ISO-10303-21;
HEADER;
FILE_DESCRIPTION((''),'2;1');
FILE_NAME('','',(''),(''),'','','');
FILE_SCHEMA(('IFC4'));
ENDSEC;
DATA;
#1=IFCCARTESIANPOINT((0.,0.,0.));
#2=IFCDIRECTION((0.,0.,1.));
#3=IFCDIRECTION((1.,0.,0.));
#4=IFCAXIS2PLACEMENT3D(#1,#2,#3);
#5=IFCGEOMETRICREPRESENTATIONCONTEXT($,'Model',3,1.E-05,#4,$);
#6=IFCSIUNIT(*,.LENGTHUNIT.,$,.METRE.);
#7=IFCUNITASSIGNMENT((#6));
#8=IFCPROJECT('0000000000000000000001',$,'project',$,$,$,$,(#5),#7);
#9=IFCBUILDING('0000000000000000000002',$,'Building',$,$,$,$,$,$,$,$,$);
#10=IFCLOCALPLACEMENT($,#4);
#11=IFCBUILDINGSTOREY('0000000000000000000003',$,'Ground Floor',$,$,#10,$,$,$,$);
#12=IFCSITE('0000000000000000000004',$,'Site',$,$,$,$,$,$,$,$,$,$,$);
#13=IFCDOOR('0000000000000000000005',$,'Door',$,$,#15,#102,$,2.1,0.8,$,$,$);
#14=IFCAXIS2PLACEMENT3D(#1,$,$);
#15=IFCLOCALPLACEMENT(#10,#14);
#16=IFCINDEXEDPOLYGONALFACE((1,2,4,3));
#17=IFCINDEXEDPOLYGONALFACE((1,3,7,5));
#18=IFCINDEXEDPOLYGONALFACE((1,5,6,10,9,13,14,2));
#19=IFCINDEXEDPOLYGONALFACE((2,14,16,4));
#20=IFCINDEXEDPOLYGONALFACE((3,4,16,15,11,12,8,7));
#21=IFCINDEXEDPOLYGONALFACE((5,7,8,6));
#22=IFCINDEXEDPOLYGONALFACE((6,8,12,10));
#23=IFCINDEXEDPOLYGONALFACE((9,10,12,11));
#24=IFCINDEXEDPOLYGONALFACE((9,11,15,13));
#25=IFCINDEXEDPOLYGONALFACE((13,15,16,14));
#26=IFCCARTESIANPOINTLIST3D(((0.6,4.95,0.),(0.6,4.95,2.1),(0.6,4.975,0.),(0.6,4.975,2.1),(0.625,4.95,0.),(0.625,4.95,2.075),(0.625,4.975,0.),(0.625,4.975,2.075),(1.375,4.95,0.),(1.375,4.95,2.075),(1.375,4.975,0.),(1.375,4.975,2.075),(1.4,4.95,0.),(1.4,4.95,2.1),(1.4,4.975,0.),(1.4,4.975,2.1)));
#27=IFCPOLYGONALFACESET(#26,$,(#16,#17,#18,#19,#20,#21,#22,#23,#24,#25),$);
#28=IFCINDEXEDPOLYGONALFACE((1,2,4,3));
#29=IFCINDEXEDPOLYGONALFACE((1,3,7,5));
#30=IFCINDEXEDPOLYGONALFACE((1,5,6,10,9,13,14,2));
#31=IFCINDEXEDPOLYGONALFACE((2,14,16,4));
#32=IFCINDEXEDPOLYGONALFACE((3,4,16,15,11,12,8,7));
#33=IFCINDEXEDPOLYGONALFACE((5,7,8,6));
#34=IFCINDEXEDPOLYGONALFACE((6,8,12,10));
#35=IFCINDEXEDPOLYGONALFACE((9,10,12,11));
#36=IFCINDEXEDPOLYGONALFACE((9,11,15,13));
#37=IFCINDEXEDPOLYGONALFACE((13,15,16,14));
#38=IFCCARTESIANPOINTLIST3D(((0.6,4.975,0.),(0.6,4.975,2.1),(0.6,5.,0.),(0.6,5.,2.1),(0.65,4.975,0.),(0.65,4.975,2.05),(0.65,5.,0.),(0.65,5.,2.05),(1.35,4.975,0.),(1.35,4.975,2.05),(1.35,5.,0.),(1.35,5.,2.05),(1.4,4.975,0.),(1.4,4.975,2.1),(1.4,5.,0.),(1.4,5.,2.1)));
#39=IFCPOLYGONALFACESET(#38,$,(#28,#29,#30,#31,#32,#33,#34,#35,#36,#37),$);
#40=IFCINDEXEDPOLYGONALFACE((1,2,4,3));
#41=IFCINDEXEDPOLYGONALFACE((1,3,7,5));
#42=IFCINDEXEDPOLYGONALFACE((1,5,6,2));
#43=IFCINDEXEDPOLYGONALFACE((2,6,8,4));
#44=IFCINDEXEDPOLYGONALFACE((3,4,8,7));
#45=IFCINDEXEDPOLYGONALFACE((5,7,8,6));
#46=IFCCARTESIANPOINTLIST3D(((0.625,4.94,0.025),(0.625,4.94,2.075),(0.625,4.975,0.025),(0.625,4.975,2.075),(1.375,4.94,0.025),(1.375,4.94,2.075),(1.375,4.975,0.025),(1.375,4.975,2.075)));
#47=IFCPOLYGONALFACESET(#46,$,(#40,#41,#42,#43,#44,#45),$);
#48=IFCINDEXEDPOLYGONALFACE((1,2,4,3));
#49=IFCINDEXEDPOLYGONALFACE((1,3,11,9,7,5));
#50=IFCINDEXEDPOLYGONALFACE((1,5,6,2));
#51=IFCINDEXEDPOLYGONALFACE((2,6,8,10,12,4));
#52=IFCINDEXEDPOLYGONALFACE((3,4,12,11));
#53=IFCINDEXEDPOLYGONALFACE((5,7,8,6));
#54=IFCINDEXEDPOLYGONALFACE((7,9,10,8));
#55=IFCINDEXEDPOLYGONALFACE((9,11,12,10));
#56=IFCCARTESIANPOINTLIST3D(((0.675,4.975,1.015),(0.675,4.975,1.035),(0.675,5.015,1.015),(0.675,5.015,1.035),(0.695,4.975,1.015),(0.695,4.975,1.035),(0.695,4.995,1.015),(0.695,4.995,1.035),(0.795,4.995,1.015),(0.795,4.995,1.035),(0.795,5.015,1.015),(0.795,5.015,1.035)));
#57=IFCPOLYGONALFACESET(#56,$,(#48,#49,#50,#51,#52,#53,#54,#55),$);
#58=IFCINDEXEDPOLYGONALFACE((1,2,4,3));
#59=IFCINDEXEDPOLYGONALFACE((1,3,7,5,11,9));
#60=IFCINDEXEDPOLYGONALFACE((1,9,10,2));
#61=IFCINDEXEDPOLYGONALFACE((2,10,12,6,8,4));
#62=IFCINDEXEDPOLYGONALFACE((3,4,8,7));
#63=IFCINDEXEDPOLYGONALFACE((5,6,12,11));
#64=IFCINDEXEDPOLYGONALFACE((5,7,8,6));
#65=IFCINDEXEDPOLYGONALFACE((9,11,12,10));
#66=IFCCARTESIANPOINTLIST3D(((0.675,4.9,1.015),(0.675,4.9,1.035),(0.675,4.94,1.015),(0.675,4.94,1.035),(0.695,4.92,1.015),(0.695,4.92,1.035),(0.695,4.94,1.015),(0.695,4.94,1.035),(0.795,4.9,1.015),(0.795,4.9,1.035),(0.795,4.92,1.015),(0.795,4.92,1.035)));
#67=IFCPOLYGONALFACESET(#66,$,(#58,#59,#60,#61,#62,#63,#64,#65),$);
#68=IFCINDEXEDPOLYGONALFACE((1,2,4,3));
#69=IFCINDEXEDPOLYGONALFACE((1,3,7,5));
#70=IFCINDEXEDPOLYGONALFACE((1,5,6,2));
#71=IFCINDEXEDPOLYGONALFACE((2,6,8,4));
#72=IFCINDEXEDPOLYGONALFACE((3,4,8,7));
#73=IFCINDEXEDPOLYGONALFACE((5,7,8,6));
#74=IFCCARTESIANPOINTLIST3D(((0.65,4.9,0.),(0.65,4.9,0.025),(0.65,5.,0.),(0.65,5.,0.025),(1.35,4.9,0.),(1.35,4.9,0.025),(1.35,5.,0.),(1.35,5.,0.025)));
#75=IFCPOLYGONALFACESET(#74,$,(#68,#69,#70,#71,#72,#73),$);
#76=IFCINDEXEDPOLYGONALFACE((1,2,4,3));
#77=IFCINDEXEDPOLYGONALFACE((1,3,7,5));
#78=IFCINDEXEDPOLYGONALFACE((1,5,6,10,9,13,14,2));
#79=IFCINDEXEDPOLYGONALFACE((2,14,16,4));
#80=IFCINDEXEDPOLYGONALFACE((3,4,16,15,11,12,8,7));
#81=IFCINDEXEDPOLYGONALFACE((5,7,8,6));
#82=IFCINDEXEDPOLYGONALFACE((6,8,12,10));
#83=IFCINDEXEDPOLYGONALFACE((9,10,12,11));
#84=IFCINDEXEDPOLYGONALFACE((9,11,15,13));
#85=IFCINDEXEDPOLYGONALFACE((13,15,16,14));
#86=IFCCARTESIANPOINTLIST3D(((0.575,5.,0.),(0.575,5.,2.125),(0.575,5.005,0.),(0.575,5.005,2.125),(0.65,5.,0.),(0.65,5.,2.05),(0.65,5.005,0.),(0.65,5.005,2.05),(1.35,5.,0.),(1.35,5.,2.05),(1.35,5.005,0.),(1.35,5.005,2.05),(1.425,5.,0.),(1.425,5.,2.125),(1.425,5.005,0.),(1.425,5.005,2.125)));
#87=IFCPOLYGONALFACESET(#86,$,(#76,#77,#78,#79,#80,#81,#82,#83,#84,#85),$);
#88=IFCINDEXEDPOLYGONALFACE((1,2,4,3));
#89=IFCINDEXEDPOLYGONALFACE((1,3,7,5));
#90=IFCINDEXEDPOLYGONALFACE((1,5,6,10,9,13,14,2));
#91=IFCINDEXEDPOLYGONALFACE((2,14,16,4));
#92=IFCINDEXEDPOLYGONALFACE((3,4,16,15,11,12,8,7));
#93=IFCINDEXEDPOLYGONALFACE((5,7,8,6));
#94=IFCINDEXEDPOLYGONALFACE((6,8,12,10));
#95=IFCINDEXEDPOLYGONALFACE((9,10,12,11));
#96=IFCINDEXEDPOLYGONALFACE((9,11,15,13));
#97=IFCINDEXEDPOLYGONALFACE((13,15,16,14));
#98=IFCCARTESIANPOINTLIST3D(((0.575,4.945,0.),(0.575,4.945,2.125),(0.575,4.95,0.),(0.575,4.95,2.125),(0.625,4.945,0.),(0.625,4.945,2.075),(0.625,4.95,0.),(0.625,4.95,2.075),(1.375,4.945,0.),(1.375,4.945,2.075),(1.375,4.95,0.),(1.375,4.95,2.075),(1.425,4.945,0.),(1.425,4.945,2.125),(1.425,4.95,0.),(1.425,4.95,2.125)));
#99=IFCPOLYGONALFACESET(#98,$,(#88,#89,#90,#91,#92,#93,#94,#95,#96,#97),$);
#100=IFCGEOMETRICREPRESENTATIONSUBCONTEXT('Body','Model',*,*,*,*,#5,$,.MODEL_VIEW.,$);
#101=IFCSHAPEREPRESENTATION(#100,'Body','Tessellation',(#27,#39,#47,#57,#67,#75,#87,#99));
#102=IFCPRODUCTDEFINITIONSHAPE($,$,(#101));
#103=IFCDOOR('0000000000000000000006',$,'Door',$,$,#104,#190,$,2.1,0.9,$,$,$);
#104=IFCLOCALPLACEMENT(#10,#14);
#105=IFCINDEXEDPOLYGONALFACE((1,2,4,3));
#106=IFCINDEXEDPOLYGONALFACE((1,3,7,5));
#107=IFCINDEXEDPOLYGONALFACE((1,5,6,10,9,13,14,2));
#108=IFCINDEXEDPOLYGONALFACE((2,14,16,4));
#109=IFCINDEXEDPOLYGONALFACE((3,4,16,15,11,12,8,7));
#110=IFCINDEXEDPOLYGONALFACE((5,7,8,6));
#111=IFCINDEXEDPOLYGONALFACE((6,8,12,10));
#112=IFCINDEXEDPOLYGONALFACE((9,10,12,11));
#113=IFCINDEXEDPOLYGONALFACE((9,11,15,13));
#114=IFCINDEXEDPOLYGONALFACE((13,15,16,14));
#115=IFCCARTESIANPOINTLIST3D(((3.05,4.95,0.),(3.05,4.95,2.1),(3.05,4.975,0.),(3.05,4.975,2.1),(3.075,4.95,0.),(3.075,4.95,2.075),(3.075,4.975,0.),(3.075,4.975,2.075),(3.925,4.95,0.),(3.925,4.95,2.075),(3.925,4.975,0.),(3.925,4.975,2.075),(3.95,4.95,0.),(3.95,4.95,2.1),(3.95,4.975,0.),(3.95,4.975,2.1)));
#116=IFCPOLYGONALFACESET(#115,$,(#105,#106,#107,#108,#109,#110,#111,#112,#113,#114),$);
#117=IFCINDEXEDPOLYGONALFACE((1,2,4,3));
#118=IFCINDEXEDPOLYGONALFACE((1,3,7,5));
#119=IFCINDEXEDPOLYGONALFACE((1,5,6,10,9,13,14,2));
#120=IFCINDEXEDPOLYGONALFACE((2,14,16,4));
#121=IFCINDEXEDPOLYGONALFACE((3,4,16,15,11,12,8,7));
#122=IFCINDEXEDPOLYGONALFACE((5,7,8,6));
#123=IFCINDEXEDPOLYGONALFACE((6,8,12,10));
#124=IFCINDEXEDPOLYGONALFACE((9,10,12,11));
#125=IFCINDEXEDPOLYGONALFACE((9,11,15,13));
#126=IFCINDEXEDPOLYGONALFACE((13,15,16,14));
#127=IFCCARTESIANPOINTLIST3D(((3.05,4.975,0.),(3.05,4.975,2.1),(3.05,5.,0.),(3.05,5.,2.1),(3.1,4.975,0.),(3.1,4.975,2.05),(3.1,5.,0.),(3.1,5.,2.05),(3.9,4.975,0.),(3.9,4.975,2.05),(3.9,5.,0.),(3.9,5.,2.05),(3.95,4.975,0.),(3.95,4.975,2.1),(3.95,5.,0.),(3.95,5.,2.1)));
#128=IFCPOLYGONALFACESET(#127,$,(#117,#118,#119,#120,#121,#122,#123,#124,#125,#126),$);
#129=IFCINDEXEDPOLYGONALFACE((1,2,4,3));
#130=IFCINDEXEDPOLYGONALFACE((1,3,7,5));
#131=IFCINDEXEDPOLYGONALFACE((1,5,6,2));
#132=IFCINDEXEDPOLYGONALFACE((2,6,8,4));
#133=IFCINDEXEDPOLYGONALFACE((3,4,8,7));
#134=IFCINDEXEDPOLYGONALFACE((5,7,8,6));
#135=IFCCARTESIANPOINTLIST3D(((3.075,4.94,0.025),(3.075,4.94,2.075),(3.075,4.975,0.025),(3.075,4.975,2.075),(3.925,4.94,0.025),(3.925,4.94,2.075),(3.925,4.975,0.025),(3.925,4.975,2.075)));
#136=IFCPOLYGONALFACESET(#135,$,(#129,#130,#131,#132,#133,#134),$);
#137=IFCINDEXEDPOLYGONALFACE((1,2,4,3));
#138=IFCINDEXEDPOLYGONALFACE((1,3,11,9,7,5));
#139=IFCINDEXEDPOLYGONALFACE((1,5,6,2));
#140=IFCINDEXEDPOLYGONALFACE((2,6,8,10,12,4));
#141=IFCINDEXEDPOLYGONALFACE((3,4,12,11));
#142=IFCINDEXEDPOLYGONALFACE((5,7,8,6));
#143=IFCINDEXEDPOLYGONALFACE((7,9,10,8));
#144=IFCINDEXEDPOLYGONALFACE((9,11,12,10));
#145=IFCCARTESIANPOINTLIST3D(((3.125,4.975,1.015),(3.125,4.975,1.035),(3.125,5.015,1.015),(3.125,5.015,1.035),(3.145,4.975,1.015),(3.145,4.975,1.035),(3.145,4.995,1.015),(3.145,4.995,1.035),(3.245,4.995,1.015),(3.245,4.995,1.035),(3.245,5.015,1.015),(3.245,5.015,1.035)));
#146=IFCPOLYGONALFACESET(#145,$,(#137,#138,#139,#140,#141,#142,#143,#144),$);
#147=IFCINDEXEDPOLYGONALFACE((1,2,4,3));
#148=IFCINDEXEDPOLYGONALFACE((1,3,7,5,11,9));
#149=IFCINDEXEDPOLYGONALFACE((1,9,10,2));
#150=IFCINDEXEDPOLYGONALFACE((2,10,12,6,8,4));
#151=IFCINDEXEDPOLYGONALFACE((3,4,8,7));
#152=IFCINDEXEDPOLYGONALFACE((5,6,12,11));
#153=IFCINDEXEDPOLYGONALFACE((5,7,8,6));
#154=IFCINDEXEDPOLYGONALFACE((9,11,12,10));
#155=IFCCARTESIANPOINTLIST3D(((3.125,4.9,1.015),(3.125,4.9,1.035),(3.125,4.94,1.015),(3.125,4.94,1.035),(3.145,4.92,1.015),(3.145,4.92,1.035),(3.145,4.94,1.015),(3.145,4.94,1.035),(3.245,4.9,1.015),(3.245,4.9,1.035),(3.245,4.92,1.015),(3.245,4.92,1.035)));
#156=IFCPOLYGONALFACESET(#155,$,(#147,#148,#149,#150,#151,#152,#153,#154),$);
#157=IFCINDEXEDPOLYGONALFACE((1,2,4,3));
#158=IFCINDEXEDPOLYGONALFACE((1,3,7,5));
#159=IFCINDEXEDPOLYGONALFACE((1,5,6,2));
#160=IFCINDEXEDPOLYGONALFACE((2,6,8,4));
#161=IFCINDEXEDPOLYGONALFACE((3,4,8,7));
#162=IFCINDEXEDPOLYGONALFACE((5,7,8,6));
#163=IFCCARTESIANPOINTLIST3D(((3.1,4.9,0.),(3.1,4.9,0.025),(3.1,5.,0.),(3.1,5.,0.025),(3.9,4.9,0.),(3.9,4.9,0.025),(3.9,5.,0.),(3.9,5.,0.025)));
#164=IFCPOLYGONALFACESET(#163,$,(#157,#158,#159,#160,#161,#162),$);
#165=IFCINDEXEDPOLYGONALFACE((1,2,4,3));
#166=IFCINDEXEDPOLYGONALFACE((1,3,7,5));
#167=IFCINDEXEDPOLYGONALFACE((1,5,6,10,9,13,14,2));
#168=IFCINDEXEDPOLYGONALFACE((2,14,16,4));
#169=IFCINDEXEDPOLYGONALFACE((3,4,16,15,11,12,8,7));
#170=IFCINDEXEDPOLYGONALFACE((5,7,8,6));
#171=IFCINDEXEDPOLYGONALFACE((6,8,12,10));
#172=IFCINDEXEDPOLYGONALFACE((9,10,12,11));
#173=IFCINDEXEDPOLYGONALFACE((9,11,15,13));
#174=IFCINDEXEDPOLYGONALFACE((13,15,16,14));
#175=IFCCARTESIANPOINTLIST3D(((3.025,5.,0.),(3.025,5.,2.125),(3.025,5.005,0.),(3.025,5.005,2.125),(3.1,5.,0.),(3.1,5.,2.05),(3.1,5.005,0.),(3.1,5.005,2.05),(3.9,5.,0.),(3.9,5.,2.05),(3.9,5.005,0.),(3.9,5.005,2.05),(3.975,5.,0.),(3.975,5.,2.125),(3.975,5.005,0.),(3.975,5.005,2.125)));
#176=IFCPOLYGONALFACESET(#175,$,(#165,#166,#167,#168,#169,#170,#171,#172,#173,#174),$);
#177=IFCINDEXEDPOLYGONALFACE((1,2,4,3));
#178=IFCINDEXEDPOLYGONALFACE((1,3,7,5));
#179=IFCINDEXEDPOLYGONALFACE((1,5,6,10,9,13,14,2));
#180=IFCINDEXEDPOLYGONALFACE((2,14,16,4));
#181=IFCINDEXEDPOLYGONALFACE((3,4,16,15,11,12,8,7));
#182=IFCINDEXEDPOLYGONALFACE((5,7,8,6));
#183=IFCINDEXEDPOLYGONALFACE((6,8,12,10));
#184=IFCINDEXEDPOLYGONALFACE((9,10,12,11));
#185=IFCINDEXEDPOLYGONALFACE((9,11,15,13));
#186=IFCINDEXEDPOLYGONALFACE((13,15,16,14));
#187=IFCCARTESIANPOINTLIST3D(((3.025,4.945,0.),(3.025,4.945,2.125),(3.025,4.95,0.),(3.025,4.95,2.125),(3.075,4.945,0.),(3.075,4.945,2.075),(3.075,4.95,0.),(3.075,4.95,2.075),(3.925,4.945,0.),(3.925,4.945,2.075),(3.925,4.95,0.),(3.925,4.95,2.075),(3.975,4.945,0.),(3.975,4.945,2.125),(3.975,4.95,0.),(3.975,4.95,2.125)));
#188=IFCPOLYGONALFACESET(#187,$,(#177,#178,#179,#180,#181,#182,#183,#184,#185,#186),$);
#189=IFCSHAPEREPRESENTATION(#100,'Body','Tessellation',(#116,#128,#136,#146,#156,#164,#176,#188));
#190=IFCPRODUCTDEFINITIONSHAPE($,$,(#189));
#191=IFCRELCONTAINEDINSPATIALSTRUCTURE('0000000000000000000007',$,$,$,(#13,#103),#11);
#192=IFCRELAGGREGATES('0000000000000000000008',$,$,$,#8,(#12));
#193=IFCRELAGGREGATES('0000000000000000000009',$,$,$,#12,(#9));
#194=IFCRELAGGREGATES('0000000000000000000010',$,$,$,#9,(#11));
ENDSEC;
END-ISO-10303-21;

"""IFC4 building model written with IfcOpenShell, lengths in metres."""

from ifc_helpers import new_model, si_unit, frame, origin_with_axes, place, context, subcontext, project, spatial, line, indexed_curve, outline, extrude, element, save


model = new_model("IFC4")

# Units and contexts
model_context = context("Model", 3, precision=1e-05, world=origin_with_axes())
body_context = subcontext(model_context, "Body", "Model", "MODEL_VIEW")
ifc_project = project(units=[si_unit("LENGTHUNIT", "METRE")], contexts=[model_context])

# Site, building, storey
site = spatial("IfcSite", under=ifc_project, Name="Site")
building = spatial("IfcBuilding", under=site, Name="Building")
storey_placement = place(None, origin_with_axes())
storey = spatial("IfcBuildingStorey", under=building, at=storey_placement, Name="Ground Floor")

# Doors
door_1_placement = place(storey_placement, frame((1.4, 5.0, 0.0), z_axis=(0.0, 0.0, 1.0), x_axis=(-1.0, 0.0, 0.0)))
element("IfcDoor", 1, at=door_1_placement, inside=storey, Name="Door", OverallHeight=2.1, OverallWidth=0.8, context=body_context, shape_type="SweptSolid", body=[
    extrude(outline(indexed_curve([(0.0, 0.0), (0.0, 2.1), (0.8, 2.1), (0.8, 0.0), (0.775, 0.0), (0.775, 2.075), (0.025, 2.075), (0.025, 0.0)], segments=[line(1, 2, 3, 4, 5, 6, 7, 8, 1)])), frame((0.0, 0.025, 0.0), z_axis=(0.0, -1.0, 0.0), x_axis=(1.0, 0.0, 0.0)), (0.0, 0.0, -1.0), 0.025),
    extrude(outline(indexed_curve([(0.0, 0.0), (0.0, 2.1), (0.8, 2.1), (0.8, 0.0), (0.75, 0.0), (0.75, 2.05), (0.05, 2.05), (0.05, 0.0)], segments=[line(1, 2, 3, 4, 5, 6, 7, 8, 1)])), frame((0.0, 0.0, 0.0), z_axis=(0.0, -1.0, 0.0), x_axis=(1.0, 0.0, 0.0)), (0.0, 0.0, -1.0), 0.025),
    extrude(outline(indexed_curve([(0.0, 0.0), (0.75, 0.0), (0.75, 0.035), (0.0, 0.035)], segments=[line(1, 2, 3, 4, 1)])), frame((0.025, 0.025, 0.025), z_axis=(0.0, 0.0, 1.0), x_axis=(1.0, 0.0, 0.0)), (0.0, 0.0, 1.0), 2.05),
    extrude(outline(indexed_curve([(0.0, 0.0), (0.0, -0.04), (-0.12, -0.04), (-0.12, -0.02), (-0.02, -0.02), (-0.02, 0.0)], segments=[line(1, 2, 3, 4, 5, 6, 1)])), frame((0.725, 0.025, 1.015), z_axis=(0.0, 0.0, 1.0), x_axis=(1.0, 0.0, 0.0)), (0.0, 0.0, 1.0), 0.02),
    extrude(outline(indexed_curve([(0.0, 0.0), (0.0, 0.04), (-0.12, 0.04), (-0.12, 0.02), (-0.02, 0.02), (-0.02, 0.0)], segments=[line(1, 2, 3, 4, 5, 6, 1)])), frame((0.725, 0.06, 1.015), z_axis=(0.0, 0.0, 1.0), x_axis=(1.0, 0.0, 0.0)), (0.0, 0.0, 1.0), 0.02),
    extrude(outline(indexed_curve([(0.0, 0.0), (0.7, 0.0), (0.7, 0.1), (0.0, 0.1)], segments=[line(1, 2, 3, 4, 1)])), frame((0.05, 0.0, 0.0), z_axis=(0.0, 0.0, 1.0), x_axis=(1.0, 0.0, 0.0)), (0.0, 0.0, 1.0), 0.025),
    extrude(outline(indexed_curve([(0.0, 0.0), (0.0, 2.125), (0.85, 2.125), (0.85, 0.0), (0.775, 0.0), (0.775, 2.05), (0.075, 2.05), (0.075, 0.0)], segments=[line(1, 2, 3, 4, 5, 6, 7, 8, 1)])), frame((-0.025, -0.005, 0.0), z_axis=(0.0, -1.0, 0.0), x_axis=(1.0, 0.0, 0.0)), (0.0, 0.0, -1.0), 0.005),
    extrude(outline(indexed_curve([(0.0, 0.0), (0.0, 2.125), (0.85, 2.125), (0.85, 0.0), (0.8, 0.0), (0.8, 2.075), (0.05, 2.075), (0.05, 0.0)], segments=[line(1, 2, 3, 4, 5, 6, 7, 8, 1)])), frame((-0.025, 0.05, 0.0), z_axis=(0.0, -1.0, 0.0), x_axis=(1.0, 0.0, 0.0)), (0.0, 0.0, -1.0), 0.005),
])
door_2_placement = place(storey_placement, frame((3.95, 5.0, 0.0), z_axis=(0.0, 0.0, 1.0), x_axis=(-1.0, 0.0, 0.0)))
element("IfcDoor", 2, at=door_2_placement, inside=storey, Name="Door", OverallHeight=2.1, OverallWidth=0.9, context=body_context, shape_type="SweptSolid", body=[
    extrude(outline(indexed_curve([(0.0, 0.0), (0.0, 2.1), (0.9, 2.1), (0.9, 0.0), (0.875, 0.0), (0.875, 2.075), (0.025, 2.075), (0.025, 0.0)], segments=[line(1, 2, 3, 4, 5, 6, 7, 8, 1)])), frame((0.0, 0.025, 0.0), z_axis=(0.0, -1.0, 0.0), x_axis=(1.0, 0.0, 0.0)), (0.0, 0.0, -1.0), 0.025),
    extrude(outline(indexed_curve([(0.0, 0.0), (0.0, 2.1), (0.9, 2.1), (0.9, 0.0), (0.85, 0.0), (0.85, 2.05), (0.05, 2.05), (0.05, 0.0)], segments=[line(1, 2, 3, 4, 5, 6, 7, 8, 1)])), frame((0.0, 0.0, 0.0), z_axis=(0.0, -1.0, 0.0), x_axis=(1.0, 0.0, 0.0)), (0.0, 0.0, -1.0), 0.025),
    extrude(outline(indexed_curve([(0.0, 0.0), (0.85, 0.0), (0.85, 0.035), (0.0, 0.035)], segments=[line(1, 2, 3, 4, 1)])), frame((0.025, 0.025, 0.025), z_axis=(0.0, 0.0, 1.0), x_axis=(1.0, 0.0, 0.0)), (0.0, 0.0, 1.0), 2.05),
    extrude(outline(indexed_curve([(0.0, 0.0), (0.0, -0.04), (-0.12, -0.04), (-0.12, -0.02), (-0.02, -0.02), (-0.02, 0.0)], segments=[line(1, 2, 3, 4, 5, 6, 1)])), frame((0.825, 0.025, 1.015), z_axis=(0.0, 0.0, 1.0), x_axis=(1.0, 0.0, 0.0)), (0.0, 0.0, 1.0), 0.02),
    extrude(outline(indexed_curve([(0.0, 0.0), (0.0, 0.04), (-0.12, 0.04), (-0.12, 0.02), (-0.02, 0.02), (-0.02, 0.0)], segments=[line(1, 2, 3, 4, 5, 6, 1)])), frame((0.825, 0.06, 1.015), z_axis=(0.0, 0.0, 1.0), x_axis=(1.0, 0.0, 0.0)), (0.0, 0.0, 1.0), 0.02),
    extrude(outline(indexed_curve([(0.0, 0.0), (0.8, 0.0), (0.8, 0.1), (0.0, 0.1)], segments=[line(1, 2, 3, 4, 1)])), frame((0.05, 0.0, 0.0), z_axis=(0.0, 0.0, 1.0), x_axis=(1.0, 0.0, 0.0)), (0.0, 0.0, 1.0), 0.025),
    extrude(outline(indexed_curve([(0.0, 0.0), (0.0, 2.125), (0.95, 2.125), (0.95, 0.0), (0.875, 0.0), (0.875, 2.05), (0.075, 2.05), (0.075, 0.0)], segments=[line(1, 2, 3, 4, 5, 6, 7, 8, 1)])), frame((-0.025, -0.005, 0.0), z_axis=(0.0, -1.0, 0.0), x_axis=(1.0, 0.0, 0.0)), (0.0, 0.0, -1.0), 0.005),
    extrude(outline(indexed_curve([(0.0, 0.0), (0.0, 2.125), (0.95, 2.125), (0.95, 0.0), (0.9, 0.0), (0.9, 2.075), (0.05, 2.075), (0.05, 0.0)], segments=[line(1, 2, 3, 4, 5, 6, 7, 8, 1)])), frame((-0.025, 0.05, 0.0), z_axis=(0.0, -1.0, 0.0), x_axis=(1.0, 0.0, 0.0)), (0.0, 0.0, -1.0), 0.005),
])

save(model, "model.ifc")
